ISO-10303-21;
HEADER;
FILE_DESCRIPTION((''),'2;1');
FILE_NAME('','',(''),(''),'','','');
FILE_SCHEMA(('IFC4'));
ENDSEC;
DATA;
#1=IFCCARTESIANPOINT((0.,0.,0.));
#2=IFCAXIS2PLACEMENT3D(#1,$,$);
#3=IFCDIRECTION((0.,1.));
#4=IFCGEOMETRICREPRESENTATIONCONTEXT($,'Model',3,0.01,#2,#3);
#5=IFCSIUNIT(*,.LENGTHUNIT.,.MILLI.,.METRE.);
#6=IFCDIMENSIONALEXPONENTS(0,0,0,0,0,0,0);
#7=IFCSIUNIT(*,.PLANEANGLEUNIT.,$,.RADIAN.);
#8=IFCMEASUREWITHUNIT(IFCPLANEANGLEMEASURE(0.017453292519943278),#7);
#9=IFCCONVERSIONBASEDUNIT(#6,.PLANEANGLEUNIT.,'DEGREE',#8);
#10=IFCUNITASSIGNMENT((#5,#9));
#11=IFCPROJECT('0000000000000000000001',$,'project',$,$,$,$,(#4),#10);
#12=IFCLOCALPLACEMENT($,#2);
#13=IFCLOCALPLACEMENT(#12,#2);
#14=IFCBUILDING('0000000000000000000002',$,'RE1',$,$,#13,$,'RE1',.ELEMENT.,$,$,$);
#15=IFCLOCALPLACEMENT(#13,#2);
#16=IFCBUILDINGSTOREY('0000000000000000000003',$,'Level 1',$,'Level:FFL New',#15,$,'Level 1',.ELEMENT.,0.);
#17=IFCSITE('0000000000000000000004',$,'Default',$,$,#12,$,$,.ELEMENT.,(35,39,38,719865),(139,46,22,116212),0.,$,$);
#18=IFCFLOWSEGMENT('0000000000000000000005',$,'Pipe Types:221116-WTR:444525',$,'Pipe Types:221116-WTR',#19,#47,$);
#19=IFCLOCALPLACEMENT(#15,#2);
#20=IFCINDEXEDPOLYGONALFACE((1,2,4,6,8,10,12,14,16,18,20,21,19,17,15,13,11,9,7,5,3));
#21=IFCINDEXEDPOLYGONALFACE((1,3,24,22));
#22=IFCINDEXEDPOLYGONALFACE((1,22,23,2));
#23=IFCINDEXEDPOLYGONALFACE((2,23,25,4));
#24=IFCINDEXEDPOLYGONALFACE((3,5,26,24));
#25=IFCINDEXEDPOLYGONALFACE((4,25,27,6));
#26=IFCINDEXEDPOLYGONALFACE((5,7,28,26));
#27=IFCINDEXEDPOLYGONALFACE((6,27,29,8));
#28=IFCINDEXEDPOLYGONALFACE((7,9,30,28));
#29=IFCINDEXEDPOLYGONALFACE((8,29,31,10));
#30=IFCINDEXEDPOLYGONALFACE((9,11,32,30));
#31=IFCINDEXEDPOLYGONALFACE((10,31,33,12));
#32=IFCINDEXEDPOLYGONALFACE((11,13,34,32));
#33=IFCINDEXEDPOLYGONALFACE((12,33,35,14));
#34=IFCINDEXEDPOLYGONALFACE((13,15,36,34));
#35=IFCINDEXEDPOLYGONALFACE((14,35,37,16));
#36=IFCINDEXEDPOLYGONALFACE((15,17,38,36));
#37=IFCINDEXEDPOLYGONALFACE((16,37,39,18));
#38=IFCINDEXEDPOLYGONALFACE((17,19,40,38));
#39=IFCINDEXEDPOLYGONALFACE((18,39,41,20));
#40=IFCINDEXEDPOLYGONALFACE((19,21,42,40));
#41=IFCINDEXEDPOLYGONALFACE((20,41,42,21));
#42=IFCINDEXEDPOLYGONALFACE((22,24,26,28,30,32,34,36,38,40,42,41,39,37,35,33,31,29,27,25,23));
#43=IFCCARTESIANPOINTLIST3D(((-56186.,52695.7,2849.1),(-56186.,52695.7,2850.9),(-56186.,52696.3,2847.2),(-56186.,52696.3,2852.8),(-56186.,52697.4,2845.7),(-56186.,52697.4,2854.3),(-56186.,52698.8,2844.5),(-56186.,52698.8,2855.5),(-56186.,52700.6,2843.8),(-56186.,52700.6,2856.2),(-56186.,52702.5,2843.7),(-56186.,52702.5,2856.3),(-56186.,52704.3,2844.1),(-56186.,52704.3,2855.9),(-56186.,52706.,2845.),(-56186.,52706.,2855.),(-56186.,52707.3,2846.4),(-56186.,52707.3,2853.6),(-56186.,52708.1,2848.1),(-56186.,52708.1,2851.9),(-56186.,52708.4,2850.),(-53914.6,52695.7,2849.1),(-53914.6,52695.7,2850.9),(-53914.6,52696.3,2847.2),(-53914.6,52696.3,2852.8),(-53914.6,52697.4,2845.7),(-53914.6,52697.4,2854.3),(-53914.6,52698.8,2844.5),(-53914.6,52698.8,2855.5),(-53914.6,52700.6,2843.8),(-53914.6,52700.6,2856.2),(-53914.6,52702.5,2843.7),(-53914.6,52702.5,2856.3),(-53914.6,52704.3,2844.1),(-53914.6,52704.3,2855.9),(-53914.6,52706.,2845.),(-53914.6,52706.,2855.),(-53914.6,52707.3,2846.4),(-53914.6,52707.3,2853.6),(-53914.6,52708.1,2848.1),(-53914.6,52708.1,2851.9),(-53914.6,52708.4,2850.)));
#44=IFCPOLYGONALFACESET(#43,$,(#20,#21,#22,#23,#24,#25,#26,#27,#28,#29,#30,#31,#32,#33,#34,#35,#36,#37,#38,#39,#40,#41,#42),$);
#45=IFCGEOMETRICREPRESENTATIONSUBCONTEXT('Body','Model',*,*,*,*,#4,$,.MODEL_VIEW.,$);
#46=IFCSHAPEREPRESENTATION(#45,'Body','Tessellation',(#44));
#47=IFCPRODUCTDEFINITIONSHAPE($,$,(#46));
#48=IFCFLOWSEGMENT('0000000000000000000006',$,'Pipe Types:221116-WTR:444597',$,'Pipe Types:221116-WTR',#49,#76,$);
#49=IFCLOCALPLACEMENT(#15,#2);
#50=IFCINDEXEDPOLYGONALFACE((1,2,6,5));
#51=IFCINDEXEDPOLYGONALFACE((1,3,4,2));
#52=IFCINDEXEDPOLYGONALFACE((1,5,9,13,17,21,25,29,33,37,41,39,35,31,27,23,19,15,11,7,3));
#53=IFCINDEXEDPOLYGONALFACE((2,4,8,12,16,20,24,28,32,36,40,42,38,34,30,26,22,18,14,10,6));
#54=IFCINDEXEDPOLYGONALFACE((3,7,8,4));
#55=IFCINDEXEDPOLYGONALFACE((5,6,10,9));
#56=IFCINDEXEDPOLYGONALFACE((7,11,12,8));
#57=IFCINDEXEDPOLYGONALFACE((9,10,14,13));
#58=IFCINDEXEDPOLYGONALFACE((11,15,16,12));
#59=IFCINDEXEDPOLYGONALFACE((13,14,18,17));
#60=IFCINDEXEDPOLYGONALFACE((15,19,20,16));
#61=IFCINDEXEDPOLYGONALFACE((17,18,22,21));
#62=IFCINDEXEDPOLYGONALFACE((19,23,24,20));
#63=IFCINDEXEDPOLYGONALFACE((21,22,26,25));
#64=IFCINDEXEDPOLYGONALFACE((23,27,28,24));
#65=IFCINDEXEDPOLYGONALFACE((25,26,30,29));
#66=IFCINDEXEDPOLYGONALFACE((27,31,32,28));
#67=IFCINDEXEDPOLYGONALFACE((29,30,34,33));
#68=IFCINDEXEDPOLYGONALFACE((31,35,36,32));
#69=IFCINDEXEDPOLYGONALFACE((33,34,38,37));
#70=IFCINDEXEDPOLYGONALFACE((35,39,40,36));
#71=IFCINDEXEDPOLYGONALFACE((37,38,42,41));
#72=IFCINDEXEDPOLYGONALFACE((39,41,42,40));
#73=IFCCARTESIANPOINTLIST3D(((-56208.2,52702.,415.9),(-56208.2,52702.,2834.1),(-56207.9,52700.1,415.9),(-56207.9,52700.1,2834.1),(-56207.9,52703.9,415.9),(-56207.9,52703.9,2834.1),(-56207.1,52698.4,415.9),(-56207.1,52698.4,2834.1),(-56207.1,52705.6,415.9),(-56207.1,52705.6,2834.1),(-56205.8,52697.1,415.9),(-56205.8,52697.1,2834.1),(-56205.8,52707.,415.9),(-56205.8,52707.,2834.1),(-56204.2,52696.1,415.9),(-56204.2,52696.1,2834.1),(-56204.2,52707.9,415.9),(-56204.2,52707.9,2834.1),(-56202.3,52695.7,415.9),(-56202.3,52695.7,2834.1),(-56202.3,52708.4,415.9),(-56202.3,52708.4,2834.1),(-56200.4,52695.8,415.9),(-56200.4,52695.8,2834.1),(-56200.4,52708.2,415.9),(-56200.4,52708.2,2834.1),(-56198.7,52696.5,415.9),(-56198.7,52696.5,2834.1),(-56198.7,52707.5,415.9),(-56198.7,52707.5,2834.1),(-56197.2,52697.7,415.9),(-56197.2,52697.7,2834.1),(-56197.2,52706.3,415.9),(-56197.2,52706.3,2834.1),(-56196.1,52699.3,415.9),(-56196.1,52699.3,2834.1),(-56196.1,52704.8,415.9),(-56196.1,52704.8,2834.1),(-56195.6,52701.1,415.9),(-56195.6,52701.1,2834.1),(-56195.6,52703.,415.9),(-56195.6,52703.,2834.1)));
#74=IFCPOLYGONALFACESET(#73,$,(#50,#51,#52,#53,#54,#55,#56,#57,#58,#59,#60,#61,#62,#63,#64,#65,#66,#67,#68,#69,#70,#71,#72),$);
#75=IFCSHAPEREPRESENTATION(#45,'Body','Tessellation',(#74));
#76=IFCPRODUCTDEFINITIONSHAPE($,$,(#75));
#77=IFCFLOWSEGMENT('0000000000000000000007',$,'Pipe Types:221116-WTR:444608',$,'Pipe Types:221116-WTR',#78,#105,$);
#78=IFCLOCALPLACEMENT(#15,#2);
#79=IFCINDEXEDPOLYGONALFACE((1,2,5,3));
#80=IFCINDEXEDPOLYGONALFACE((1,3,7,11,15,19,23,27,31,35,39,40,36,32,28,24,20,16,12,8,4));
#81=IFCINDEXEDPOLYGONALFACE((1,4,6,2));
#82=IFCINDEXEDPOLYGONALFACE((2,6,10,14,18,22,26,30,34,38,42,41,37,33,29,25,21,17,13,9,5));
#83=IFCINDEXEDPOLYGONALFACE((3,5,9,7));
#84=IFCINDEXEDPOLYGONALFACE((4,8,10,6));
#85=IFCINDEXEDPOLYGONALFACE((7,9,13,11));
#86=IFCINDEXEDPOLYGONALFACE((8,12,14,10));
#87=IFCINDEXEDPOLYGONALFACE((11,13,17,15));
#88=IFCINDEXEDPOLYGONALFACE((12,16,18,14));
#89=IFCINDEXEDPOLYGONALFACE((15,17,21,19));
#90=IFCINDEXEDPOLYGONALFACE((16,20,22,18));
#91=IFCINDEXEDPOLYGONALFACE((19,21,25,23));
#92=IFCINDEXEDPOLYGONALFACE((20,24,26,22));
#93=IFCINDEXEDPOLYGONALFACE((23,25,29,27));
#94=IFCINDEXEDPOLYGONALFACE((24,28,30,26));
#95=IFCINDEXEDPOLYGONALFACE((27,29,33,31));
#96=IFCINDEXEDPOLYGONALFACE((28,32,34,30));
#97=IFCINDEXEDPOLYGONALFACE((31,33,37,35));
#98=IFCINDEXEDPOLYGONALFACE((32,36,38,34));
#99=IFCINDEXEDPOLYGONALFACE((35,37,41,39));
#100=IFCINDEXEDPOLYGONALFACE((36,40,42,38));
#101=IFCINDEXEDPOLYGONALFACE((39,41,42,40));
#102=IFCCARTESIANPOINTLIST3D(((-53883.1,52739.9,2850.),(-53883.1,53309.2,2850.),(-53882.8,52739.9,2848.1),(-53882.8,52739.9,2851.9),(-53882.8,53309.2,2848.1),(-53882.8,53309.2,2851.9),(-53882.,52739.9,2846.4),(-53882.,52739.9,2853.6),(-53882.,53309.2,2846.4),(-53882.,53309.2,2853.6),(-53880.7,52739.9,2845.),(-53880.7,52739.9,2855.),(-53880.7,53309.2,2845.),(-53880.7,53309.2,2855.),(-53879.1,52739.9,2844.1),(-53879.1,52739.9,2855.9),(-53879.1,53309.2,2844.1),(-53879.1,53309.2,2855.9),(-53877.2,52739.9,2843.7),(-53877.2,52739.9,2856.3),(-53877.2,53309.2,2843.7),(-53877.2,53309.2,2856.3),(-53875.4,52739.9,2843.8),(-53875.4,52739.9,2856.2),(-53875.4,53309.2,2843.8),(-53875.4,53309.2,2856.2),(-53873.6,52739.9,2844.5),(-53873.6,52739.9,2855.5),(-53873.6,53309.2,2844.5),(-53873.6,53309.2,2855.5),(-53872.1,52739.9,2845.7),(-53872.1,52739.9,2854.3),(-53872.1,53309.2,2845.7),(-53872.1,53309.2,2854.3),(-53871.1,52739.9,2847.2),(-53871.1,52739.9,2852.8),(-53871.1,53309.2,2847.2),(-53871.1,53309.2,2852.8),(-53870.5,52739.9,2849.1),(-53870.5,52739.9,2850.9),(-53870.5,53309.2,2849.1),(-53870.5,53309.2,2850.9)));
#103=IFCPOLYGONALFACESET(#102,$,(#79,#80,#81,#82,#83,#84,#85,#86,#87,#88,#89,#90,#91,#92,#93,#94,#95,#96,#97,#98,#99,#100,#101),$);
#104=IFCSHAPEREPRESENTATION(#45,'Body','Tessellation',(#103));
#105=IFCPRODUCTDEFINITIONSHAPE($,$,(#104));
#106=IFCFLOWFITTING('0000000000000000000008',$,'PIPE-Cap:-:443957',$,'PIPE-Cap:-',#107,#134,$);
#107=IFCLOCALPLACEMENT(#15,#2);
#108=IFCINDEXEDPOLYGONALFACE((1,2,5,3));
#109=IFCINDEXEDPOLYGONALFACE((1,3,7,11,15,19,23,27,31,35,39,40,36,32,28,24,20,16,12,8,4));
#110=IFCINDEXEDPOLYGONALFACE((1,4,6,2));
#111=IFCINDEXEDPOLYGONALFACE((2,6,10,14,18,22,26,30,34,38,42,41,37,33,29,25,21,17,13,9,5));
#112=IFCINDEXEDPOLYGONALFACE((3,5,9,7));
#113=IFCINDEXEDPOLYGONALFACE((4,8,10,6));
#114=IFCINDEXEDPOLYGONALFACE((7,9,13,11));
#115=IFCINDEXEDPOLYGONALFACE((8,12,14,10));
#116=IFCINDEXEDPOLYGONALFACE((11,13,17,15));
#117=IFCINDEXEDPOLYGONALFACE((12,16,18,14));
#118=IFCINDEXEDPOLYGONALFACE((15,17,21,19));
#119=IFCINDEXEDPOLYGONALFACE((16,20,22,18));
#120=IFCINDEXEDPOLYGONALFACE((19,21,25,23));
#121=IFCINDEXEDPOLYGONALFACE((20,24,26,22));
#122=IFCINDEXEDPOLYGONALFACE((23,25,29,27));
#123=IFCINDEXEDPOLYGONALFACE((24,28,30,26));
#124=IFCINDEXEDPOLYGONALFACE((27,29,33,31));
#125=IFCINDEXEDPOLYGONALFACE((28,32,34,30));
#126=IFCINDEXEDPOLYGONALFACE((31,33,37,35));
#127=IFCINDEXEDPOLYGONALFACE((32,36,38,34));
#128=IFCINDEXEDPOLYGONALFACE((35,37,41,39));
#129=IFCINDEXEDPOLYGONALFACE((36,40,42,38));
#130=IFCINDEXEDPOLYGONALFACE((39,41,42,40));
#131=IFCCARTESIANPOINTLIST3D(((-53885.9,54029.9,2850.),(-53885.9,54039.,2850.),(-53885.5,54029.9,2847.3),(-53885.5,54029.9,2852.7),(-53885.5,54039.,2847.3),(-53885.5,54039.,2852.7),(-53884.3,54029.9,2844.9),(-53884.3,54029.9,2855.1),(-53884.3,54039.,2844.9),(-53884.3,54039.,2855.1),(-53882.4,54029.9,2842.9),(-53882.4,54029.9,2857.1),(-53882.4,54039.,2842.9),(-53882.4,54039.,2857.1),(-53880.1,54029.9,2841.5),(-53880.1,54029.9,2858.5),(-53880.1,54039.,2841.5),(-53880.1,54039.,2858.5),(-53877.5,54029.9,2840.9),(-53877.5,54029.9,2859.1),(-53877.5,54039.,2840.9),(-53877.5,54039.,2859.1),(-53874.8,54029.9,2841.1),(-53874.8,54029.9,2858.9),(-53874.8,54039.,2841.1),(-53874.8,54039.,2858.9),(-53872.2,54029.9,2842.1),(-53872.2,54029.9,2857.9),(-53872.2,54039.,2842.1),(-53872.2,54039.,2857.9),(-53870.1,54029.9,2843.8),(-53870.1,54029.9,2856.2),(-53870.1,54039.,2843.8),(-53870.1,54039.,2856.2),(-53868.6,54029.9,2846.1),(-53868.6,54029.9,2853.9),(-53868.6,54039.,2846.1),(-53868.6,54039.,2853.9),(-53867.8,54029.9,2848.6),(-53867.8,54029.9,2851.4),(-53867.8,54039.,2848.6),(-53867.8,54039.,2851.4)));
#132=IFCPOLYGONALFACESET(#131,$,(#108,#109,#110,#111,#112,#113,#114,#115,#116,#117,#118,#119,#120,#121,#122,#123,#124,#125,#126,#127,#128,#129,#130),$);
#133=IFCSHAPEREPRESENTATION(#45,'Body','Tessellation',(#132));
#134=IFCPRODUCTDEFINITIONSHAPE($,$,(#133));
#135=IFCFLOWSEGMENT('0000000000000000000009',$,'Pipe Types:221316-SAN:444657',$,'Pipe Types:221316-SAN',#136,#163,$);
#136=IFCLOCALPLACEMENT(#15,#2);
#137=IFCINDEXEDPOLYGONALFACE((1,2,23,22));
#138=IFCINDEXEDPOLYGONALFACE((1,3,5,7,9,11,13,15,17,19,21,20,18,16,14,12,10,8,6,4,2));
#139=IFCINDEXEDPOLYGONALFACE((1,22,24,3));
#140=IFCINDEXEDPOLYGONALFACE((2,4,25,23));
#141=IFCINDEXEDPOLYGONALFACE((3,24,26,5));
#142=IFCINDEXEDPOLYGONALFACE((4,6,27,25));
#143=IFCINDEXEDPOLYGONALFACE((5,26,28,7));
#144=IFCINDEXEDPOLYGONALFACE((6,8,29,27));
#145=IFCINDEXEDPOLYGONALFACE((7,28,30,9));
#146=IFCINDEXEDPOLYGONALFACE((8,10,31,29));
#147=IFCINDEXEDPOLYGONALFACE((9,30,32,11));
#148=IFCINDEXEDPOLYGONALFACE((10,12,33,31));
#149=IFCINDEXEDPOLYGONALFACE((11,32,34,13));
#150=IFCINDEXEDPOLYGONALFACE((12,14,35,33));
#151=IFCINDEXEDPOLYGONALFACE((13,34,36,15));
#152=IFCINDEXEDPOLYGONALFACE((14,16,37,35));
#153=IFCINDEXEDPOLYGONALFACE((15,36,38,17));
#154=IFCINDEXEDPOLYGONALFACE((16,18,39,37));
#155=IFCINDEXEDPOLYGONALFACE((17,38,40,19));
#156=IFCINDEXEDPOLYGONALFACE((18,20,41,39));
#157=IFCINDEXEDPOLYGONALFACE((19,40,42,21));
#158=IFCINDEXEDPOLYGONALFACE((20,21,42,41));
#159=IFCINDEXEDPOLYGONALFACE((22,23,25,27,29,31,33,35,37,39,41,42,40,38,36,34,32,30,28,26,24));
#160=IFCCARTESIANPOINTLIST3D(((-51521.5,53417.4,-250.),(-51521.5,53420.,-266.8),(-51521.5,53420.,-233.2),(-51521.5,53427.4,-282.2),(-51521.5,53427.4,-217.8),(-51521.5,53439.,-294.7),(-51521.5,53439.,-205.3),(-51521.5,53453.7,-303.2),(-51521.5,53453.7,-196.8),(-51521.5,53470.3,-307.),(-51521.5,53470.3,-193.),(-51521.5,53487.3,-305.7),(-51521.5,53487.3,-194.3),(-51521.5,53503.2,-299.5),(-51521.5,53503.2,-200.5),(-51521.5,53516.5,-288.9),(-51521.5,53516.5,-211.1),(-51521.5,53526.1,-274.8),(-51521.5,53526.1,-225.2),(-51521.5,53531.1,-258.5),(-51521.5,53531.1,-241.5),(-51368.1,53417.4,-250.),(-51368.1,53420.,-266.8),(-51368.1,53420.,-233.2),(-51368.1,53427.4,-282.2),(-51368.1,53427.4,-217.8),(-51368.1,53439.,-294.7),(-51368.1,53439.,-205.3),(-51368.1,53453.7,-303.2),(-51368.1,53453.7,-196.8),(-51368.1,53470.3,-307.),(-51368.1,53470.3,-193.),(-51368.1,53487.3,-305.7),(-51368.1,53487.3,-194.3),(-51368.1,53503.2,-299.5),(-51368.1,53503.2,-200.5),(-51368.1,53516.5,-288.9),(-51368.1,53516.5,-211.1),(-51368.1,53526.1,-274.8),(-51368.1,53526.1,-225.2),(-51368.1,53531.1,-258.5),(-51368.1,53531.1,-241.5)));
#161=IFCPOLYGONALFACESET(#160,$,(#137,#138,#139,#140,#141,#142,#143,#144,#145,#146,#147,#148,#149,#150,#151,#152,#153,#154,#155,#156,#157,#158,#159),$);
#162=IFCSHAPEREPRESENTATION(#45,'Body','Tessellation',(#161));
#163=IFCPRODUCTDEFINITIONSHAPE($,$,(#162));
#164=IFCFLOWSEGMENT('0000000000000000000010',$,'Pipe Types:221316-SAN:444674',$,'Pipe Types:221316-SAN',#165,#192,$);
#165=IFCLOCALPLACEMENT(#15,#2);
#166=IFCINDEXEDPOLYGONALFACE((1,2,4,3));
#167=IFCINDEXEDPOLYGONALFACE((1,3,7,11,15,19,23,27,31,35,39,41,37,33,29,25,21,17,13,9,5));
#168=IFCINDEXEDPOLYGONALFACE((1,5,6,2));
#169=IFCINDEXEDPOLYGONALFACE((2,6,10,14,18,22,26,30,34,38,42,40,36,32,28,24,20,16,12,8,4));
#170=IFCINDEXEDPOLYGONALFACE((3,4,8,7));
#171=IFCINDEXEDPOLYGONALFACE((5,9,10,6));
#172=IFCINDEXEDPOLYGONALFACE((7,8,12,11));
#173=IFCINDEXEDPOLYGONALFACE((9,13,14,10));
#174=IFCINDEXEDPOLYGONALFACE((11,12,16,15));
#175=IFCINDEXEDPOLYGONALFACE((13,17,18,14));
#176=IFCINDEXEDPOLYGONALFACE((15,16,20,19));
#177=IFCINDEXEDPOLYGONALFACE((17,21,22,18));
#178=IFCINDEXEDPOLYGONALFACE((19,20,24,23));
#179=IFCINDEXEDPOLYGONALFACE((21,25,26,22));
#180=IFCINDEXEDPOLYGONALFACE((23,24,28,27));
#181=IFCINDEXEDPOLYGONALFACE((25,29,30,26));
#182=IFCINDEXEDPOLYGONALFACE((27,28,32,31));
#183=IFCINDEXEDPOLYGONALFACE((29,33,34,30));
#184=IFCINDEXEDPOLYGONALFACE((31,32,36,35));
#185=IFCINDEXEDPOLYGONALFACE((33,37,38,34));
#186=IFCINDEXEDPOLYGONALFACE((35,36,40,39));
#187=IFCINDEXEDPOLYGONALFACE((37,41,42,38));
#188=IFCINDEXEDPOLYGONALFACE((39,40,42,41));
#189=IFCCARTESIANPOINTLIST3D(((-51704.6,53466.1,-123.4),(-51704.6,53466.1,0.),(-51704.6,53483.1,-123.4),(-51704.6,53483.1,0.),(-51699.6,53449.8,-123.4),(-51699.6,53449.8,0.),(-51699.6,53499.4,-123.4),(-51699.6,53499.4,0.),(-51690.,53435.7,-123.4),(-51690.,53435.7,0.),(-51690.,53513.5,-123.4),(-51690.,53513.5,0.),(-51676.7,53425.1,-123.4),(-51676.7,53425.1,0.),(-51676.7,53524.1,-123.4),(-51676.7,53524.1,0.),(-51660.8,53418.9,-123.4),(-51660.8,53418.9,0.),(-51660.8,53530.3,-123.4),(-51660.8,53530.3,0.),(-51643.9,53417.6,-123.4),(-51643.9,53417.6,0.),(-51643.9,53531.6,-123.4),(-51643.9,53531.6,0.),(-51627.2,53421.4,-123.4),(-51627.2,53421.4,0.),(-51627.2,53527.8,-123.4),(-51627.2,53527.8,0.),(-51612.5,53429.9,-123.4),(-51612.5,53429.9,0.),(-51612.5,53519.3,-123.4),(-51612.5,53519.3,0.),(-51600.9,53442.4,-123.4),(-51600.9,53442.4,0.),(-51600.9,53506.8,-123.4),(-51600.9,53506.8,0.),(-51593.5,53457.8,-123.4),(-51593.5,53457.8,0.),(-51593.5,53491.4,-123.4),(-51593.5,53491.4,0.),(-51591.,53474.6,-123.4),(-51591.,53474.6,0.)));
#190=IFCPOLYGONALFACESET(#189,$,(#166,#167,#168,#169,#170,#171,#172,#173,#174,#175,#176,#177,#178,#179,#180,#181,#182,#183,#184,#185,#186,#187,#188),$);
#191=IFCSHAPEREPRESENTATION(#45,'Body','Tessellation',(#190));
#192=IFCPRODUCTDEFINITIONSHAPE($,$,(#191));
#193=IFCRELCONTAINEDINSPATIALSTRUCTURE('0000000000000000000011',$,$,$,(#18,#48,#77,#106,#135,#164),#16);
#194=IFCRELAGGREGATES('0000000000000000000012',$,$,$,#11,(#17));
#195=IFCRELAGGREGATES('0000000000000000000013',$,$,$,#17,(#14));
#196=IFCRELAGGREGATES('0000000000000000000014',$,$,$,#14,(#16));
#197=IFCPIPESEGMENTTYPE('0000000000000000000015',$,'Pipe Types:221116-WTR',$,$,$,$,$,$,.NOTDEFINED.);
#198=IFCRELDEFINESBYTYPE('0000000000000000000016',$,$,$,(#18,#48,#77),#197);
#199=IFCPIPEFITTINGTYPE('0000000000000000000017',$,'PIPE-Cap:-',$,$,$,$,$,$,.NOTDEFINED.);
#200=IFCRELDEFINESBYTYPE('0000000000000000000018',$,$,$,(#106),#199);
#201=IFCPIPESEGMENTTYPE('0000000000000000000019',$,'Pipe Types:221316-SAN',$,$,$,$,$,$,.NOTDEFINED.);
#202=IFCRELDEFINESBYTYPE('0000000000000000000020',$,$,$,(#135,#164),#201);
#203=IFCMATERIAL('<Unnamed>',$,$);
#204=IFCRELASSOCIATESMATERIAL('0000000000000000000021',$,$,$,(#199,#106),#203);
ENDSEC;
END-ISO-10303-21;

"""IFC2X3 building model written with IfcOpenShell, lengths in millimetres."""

from ifc_helpers import new_model, entity, si_unit, converted_unit, direction, frame, frame_2d, origin, origin_2d_with_axis, place, context, subcontext, project, spatial, circle, extrude, source, transform, mapped, material, type_object, type_shapes, element, save


model = new_model("IFC2X3")

# Units and contexts
model_context = context("Model", 3, precision=0.01, world=origin(), true_north=direction((0.0, 1.0)))
body_context = subcontext(model_context, "Body", "Model", "MODEL_VIEW")
ifc_project = project(units=[si_unit("LENGTHUNIT", "METRE", prefix="MILLI"), converted_unit("PLANEANGLEUNIT", "DEGREE", entity("IfcPlaneAngleMeasure", 0.017453292519943278), si_unit("PLANEANGLEUNIT", "RADIAN"), dimensions=[0, 0, 0, 0, 0, 0, 0])], contexts=[model_context])

# Site, building, storey
site_placement = place(None, origin())
site = spatial("IfcSite", under=ifc_project, at=site_placement, Name="Default", CompositionType="ELEMENT", RefLatitude=(35, 39, 38, 719865), RefLongitude=(139, 46, 22, 116212), RefElevation=0.0)
building_placement = place(site_placement, origin())
building = spatial("IfcBuilding", under=site, at=building_placement, Name="RE1", LongName="RE1", CompositionType="ELEMENT")
storey_placement = place(building_placement, origin())
storey = spatial("IfcBuildingStorey", under=building, at=storey_placement, Name="Level 1", ObjectType="Level:FFL New", LongName="Level 1", CompositionType="ELEMENT", Elevation=0.0)

# Shared definitions
ifc_material = material(Name="<Unnamed>")

# Flow segments
pipe_segment_type_1 = type_object("IfcPipeSegmentType", Name="Pipe Types:221116-WTR", PredefinedType="NOTDEFINED")
flow_segment_1_placement = place(storey_placement, origin())
element("IfcFlowSegment", 1, at=flow_segment_1_placement, inside=storey, type_object=pipe_segment_type_1, Name="Pipe Types:221116-WTR:444525", ObjectType="Pipe Types:221116-WTR", context=body_context, shape_type="SweptSolid", body=[
    extrude(circle(Radius=6.3, at=frame_2d((0.0, 0.0), x_axis=(1.0, 0.0))), frame((-56186.0, 52702.0, 2850.0), z_axis=(1.0, 0.0, 0.0), x_axis=(0.0, 1.0, 0.0)), (0.0, 0.0, 1.0), 2271.3),
])
flow_segment_2_placement = place(storey_placement, origin())
element("IfcFlowSegment", 2, at=flow_segment_2_placement, inside=storey, type_object=pipe_segment_type_1, Name="Pipe Types:221116-WTR:444597", ObjectType="Pipe Types:221116-WTR", context=body_context, shape_type="SweptSolid", body=[
    extrude(circle(Radius=6.3, at=frame_2d((0.0, 0.0), x_axis=(1.0, 0.0))), frame((-56201.8, 52702.0, 415.9), z_axis=(0.0, 0.0, 1.0), x_axis=(-1.0, 0.0, 0.0)), (0.0, 0.0, 1.0), 2418.2),
])
flow_segment_3_placement = place(storey_placement, origin())
element("IfcFlowSegment", 3, at=flow_segment_3_placement, inside=storey, type_object=pipe_segment_type_1, Name="Pipe Types:221116-WTR:444608", ObjectType="Pipe Types:221116-WTR", context=body_context, shape_type="SweptSolid", body=[
    extrude(circle(Radius=6.3, at=origin_2d_with_axis()), frame((-53876.8, 52739.9, 2850.0), z_axis=(0.0, 1.0, 0.0), x_axis=(-1.0, 0.0, 0.0)), (0.0, 0.0, 1.0), 569.3),
])

# Flow fitting
pipe_fitting_type = type_object("IfcPipeFittingType", Name="PIPE-Cap:-", PredefinedType="NOTDEFINED", material=ifc_material)
shared_shape_1 = source(origin(), body_context, "Body", "SweptSolid", [
    extrude(circle(Radius=9.1, at=frame_2d((0.0, 0.0), x_axis=(1.0, 0.0))), frame((0.0, 0.0, 0.0), z_axis=(1.0, 0.0, 0.0), x_axis=(0.0, 1.0, 0.0)), (0.0, 0.0, 1.0), 9.1),
])
type_shapes(pipe_fitting_type, [shared_shape_1])
flow_fitting_placement = place(storey_placement, frame((-53876.8, 54029.9, 2850.0), z_axis=(0.0, 0.0, 1.0), x_axis=(0.0, 1.0, 0.0)))
element("IfcFlowFitting", 4, at=flow_fitting_placement, inside=storey, type_object=pipe_fitting_type, material=ifc_material, Name="PIPE-Cap:-:443957", ObjectType="PIPE-Cap:-", context=body_context, shape_type="MappedRepresentation", body=[
    mapped(shared_shape_1, transform((0.0, 0.0, 0.0), scale=1.0)),
])

# Flow segments
pipe_segment_type_2 = type_object("IfcPipeSegmentType", Name="Pipe Types:221316-SAN", PredefinedType="NOTDEFINED")
flow_segment_4_placement = place(storey_placement, origin())
element("IfcFlowSegment", 5, at=flow_segment_4_placement, inside=storey, type_object=pipe_segment_type_2, Name="Pipe Types:221316-SAN:444657", ObjectType="Pipe Types:221316-SAN", context=body_context, shape_type="SweptSolid", body=[
    extrude(circle(Radius=57.2, at=frame_2d((0.0, 0.0), x_axis=(1.0, 0.0))), frame((-51521.5, 53474.6, -250.0), z_axis=(1.0, 0.0, 0.0), x_axis=(0.0, -1.0, 0.0)), (0.0, 0.0, 1.0), 153.4),
])
flow_segment_5_placement = place(storey_placement, origin())
element("IfcFlowSegment", 6, at=flow_segment_5_placement, inside=storey, type_object=pipe_segment_type_2, Name="Pipe Types:221316-SAN:444674", ObjectType="Pipe Types:221316-SAN", context=body_context, shape_type="SweptSolid", body=[
    extrude(circle(Radius=57.2, at=origin_2d_with_axis()), frame((-51648.1, 53474.6, -123.4)), (0.0, 0.0, 1.0), 123.4),
])

save(model, "model.ifc")
